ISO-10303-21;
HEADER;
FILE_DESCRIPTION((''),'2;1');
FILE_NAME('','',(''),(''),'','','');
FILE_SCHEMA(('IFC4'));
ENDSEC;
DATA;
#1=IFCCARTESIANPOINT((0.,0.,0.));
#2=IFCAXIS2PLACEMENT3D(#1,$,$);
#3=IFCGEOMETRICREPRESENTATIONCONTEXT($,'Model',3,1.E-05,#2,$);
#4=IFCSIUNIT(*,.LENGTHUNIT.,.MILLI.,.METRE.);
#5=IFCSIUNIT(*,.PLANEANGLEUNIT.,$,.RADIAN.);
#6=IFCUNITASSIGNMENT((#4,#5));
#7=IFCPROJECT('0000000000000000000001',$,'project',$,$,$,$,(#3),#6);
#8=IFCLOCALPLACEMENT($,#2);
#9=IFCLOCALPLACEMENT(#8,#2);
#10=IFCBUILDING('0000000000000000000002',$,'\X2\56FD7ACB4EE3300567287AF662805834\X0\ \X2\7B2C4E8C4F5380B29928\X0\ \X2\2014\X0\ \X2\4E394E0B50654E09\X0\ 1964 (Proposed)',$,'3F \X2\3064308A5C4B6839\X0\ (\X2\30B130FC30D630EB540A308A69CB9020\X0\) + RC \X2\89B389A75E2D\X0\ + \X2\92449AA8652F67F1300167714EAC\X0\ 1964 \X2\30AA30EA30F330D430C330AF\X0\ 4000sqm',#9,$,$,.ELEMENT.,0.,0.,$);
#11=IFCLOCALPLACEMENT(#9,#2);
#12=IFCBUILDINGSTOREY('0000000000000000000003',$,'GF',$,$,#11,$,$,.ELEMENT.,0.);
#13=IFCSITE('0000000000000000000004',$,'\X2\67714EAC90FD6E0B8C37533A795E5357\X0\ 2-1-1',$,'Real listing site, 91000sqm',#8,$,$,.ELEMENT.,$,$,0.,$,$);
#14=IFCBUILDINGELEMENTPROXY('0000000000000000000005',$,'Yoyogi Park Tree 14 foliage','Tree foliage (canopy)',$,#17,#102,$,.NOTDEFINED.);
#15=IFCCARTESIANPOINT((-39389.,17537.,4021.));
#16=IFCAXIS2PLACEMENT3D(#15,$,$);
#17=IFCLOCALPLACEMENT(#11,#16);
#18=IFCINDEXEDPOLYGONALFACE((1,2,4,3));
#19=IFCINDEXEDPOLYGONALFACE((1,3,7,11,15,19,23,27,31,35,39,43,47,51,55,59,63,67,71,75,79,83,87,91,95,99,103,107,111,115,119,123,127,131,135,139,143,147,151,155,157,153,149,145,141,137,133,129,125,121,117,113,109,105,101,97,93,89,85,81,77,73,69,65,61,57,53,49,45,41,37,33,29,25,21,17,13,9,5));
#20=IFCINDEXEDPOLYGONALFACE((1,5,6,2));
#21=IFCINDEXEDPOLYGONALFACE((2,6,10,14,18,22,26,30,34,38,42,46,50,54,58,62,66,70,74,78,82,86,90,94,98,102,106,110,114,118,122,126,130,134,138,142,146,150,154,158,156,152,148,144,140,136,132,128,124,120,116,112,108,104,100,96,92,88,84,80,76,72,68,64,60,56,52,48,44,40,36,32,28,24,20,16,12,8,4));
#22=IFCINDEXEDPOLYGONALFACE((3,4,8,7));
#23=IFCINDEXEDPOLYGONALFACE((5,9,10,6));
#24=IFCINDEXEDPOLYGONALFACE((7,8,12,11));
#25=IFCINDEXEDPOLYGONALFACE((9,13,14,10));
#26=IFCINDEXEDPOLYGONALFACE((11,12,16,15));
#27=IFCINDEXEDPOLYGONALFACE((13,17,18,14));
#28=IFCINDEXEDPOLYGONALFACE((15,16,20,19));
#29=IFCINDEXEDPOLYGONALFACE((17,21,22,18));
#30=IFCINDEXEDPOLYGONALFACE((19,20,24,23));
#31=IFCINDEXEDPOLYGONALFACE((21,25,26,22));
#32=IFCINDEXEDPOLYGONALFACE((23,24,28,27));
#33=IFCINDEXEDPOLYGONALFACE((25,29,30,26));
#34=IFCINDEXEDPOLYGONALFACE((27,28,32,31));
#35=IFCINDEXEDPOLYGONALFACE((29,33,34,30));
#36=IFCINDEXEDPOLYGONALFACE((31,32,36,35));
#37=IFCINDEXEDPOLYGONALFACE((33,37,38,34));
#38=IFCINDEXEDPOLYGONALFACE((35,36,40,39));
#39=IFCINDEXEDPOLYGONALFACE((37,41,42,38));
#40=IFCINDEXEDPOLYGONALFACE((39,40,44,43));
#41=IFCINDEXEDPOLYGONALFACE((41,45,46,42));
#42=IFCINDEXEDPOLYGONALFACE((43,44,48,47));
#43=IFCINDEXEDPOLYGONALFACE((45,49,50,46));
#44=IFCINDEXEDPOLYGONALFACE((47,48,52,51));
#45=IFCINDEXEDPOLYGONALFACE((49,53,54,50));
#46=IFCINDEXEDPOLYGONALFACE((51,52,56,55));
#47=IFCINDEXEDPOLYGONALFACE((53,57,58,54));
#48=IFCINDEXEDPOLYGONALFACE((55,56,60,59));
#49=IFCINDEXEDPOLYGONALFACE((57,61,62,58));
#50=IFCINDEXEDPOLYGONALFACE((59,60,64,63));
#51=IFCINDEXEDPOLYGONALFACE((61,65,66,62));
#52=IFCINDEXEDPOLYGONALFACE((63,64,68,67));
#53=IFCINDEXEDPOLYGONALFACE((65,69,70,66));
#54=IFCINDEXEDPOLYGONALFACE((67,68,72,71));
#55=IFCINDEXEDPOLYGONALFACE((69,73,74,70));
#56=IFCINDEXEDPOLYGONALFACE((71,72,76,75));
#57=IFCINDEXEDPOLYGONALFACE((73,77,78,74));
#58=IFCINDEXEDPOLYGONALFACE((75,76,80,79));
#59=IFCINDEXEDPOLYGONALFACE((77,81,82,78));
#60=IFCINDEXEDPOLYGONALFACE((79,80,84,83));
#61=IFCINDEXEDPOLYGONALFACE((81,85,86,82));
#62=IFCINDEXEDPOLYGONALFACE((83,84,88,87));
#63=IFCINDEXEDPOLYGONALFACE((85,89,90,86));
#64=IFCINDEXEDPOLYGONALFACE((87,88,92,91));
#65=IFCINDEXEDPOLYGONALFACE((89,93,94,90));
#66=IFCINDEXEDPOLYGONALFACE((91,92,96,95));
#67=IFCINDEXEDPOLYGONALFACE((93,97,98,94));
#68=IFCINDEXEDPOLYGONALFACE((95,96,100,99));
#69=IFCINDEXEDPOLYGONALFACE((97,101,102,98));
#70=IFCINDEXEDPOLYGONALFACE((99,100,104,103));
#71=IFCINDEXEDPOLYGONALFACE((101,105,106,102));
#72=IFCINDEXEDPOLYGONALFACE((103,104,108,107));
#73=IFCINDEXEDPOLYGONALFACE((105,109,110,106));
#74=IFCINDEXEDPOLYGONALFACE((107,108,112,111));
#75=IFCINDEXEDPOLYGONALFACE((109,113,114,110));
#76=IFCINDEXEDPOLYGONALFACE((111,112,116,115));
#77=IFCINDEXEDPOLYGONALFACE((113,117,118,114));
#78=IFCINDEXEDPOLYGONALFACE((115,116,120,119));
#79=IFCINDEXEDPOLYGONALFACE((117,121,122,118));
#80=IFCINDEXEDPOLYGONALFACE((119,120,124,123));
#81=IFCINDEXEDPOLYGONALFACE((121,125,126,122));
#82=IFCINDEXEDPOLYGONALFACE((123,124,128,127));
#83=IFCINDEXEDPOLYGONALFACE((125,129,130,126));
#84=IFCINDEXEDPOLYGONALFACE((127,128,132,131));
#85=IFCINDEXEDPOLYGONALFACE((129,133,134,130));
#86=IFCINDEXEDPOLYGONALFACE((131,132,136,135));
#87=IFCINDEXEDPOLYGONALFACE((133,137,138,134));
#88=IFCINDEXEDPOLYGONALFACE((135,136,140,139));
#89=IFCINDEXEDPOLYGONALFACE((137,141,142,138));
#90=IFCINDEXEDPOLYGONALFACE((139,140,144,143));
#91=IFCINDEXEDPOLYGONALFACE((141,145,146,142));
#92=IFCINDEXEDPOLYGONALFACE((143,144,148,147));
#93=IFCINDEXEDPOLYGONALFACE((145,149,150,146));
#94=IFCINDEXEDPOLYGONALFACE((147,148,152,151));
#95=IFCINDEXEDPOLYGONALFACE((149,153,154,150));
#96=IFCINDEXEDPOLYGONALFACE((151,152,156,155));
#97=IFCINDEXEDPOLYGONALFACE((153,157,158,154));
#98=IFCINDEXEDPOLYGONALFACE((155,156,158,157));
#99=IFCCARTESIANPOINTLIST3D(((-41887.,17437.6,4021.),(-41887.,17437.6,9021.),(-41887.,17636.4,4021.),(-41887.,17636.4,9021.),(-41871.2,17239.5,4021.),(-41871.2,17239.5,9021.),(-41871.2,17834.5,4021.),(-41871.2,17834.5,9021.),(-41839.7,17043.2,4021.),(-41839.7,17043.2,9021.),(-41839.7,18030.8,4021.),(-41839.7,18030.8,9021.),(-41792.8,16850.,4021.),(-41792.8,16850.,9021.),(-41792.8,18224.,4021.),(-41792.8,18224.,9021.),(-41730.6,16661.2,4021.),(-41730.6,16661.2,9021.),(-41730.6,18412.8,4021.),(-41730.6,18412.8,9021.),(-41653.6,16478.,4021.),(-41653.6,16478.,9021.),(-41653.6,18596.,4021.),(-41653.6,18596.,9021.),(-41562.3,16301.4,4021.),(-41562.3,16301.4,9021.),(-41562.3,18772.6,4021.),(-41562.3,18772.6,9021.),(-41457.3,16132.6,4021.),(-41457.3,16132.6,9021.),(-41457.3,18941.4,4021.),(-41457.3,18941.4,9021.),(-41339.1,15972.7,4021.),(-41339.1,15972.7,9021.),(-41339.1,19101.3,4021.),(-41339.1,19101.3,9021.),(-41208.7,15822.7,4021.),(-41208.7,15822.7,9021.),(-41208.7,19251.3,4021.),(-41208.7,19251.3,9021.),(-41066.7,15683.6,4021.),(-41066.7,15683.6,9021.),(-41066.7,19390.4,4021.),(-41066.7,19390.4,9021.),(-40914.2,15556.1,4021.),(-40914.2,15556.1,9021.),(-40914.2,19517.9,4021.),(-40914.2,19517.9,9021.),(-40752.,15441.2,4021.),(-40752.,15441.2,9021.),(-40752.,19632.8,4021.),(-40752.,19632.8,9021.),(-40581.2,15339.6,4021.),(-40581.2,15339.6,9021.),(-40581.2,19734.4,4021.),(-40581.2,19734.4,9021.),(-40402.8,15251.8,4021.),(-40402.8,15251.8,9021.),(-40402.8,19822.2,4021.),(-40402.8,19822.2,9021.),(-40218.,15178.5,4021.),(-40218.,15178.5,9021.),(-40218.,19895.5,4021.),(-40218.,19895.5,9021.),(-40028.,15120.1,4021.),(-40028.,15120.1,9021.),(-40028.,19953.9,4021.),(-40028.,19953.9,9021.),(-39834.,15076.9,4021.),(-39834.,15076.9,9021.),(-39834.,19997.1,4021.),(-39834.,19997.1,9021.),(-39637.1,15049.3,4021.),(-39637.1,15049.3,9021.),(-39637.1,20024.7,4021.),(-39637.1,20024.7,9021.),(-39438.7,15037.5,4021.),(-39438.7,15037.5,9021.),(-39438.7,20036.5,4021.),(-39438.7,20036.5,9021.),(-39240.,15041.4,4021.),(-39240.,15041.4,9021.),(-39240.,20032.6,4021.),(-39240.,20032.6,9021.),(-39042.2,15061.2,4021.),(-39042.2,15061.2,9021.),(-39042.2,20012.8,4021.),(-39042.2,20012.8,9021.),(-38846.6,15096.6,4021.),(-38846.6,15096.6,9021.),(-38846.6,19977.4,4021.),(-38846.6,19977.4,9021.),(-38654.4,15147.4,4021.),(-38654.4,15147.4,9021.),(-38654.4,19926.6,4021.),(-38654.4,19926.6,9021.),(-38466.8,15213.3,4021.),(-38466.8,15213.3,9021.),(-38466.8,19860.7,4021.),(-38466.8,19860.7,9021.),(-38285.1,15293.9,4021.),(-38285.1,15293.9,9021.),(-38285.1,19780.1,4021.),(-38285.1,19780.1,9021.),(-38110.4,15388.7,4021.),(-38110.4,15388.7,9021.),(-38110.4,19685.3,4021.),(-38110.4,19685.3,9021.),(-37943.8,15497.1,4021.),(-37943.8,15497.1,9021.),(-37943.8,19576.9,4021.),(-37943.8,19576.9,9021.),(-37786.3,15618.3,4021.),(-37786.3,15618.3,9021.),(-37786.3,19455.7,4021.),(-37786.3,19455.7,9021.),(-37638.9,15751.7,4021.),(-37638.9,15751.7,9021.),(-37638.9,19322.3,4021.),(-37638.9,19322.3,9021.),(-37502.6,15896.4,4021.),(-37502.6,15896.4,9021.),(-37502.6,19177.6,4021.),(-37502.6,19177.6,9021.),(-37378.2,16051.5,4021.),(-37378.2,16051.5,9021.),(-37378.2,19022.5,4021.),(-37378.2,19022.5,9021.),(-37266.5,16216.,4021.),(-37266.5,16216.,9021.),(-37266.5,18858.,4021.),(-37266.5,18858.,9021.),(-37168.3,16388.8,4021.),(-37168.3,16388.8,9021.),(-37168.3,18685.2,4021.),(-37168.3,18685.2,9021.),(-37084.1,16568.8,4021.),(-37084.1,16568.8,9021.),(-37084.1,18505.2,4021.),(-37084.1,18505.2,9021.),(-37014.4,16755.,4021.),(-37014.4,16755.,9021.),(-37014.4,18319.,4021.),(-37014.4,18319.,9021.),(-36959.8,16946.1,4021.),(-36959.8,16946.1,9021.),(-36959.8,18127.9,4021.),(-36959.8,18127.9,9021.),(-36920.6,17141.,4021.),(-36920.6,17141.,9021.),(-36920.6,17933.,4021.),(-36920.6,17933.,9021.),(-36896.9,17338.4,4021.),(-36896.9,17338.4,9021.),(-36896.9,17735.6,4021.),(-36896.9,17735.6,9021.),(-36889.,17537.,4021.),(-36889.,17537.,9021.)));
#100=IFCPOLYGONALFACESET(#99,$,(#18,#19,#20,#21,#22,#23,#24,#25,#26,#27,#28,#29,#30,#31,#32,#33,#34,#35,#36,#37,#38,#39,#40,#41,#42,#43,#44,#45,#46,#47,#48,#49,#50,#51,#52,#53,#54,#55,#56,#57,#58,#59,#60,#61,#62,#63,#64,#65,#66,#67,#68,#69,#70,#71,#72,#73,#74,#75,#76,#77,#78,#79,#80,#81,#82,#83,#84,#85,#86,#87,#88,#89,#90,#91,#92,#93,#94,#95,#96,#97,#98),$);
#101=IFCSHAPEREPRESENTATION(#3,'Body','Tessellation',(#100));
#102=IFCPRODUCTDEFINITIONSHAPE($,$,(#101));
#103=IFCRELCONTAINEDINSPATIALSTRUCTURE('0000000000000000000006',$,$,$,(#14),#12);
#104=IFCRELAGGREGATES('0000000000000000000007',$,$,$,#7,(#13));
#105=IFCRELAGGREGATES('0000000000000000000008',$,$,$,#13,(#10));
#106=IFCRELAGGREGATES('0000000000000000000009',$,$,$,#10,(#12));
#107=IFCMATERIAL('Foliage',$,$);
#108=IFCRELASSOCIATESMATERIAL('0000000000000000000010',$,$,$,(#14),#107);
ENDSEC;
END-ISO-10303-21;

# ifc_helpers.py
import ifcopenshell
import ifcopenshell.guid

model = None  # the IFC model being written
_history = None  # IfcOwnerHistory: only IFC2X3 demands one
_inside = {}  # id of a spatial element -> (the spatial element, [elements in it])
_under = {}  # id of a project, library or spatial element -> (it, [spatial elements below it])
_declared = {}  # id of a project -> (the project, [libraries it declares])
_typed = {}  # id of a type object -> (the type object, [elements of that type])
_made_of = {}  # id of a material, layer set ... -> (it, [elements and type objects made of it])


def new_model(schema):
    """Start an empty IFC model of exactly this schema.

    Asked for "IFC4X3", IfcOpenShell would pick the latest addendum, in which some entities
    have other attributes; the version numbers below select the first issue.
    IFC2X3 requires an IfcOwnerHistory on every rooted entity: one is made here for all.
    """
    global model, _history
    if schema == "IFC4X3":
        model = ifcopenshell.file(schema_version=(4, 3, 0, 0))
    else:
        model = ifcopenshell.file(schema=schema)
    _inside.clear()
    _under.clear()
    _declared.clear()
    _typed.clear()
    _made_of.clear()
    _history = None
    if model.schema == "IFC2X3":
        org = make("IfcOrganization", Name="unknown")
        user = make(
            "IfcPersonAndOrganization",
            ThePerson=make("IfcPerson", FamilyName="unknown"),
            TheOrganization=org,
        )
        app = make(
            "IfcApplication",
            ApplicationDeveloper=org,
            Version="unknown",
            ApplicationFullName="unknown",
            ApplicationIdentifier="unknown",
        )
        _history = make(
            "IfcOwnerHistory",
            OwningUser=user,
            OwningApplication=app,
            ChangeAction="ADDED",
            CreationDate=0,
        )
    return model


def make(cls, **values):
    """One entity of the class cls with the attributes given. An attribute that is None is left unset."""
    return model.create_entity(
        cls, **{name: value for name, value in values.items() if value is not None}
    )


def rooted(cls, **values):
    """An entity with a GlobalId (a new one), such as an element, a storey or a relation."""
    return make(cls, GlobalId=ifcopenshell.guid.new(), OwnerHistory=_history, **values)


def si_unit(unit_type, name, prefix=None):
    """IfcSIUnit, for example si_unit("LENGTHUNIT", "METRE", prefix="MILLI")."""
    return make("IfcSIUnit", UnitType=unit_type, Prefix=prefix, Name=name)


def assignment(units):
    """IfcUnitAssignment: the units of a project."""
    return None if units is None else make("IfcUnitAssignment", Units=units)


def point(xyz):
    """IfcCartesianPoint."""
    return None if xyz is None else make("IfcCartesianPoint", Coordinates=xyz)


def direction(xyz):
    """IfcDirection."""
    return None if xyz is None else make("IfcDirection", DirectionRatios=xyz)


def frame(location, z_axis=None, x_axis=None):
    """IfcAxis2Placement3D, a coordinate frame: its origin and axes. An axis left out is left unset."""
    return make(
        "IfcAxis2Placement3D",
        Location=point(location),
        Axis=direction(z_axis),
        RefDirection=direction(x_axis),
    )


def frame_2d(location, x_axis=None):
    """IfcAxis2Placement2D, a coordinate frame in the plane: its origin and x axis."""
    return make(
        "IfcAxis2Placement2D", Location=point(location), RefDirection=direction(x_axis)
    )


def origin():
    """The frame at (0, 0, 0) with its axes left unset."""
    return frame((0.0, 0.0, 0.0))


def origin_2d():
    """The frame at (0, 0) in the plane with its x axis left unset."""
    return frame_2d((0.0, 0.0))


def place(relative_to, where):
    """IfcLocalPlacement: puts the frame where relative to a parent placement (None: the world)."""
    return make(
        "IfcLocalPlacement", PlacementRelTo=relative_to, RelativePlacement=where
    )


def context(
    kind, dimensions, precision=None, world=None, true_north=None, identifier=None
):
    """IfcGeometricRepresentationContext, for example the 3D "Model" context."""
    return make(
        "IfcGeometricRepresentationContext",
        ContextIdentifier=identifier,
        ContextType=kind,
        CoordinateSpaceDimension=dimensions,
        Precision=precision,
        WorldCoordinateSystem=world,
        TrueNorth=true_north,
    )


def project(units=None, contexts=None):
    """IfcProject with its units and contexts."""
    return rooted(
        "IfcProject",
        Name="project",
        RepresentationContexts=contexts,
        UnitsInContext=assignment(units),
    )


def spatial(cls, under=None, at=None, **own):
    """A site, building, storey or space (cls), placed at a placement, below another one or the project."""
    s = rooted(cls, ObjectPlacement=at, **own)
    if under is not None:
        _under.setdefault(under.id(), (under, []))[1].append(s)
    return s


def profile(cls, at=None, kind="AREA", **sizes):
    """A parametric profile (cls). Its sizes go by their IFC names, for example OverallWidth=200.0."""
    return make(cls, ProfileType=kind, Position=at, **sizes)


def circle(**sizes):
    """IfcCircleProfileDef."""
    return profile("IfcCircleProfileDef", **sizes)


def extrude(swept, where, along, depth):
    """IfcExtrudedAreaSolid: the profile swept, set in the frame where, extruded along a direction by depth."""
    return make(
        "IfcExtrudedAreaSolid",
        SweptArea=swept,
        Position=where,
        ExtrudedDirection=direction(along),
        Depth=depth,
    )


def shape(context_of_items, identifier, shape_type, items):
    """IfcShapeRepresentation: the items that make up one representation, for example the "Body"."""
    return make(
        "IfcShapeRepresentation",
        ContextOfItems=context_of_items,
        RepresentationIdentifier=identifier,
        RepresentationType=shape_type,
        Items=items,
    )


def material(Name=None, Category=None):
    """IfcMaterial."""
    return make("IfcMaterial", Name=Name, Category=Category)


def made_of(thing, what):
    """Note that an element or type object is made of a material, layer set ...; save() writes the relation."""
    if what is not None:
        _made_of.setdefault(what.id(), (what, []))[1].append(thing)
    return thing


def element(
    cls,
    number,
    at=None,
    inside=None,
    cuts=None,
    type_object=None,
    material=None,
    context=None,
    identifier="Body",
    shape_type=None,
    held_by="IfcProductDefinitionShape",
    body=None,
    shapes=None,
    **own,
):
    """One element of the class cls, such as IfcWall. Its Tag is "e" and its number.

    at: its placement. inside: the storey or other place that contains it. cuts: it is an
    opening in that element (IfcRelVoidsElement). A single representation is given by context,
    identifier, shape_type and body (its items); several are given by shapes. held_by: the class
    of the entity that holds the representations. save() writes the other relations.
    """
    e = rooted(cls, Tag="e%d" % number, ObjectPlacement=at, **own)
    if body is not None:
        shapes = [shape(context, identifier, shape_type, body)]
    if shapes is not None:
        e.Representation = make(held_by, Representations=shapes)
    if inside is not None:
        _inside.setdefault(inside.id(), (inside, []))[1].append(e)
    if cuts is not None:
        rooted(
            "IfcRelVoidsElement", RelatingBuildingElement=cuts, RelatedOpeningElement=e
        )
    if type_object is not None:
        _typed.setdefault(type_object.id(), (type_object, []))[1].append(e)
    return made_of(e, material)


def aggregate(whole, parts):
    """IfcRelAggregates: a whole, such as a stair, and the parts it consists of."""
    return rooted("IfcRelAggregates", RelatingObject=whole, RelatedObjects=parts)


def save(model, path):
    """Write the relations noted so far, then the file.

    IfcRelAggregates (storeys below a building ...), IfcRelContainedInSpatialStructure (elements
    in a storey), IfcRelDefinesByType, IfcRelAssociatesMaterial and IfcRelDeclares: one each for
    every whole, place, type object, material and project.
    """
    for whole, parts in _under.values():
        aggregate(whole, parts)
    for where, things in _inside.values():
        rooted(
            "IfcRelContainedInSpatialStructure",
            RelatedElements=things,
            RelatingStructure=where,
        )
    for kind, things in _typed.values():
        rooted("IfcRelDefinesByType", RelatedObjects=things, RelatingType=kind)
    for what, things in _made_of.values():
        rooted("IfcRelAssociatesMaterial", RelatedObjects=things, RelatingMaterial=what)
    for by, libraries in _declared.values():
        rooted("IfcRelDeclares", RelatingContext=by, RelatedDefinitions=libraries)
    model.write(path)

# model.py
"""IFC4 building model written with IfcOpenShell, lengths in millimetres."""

from ifc_helpers import new_model, si_unit, frame, origin, origin_2d, place, context, project, spatial, circle, extrude, material, element, save


model = new_model("IFC4")

# Units and contexts
model_context = context("Model", 3, precision=1e-05, world=origin())
ifc_project = project(units=[si_unit("LENGTHUNIT", "METRE", prefix="MILLI"), si_unit("PLANEANGLEUNIT", "RADIAN")], contexts=[model_context])

# Site, building, storey
site_placement = place(None, origin())
site = spatial("IfcSite", under=ifc_project, at=site_placement, Name="東京都渋谷区神南 2-1-1", ObjectType="Real listing site, 91000sqm", CompositionType="ELEMENT", RefElevation=0.0)
building_placement = place(site_placement, origin())
building = spatial("IfcBuilding", under=site, at=building_placement, Name="国立代々木競技場 第二体育館 — 丹下健三 1964 (Proposed)", ObjectType="3F つり屋根 (ケーブル吊り構造) + RC 観覧席 + 鉄骨支柱、東京 1964 オリンピック 4000sqm", CompositionType="ELEMENT", ElevationOfRefHeight=0.0, ElevationOfTerrain=0.0)
storey_placement = place(building_placement, origin())
storey = spatial("IfcBuildingStorey", under=building, at=storey_placement, Name="GF", CompositionType="ELEMENT", Elevation=0.0)

# Building element proxy
ifc_material_1 = material(Name="Foliage")
proxy_1_placement = place(storey_placement, frame((-39389.0, 17537.0, 4021.0)))
element("IfcBuildingElementProxy", 1, at=proxy_1_placement, inside=storey, material=ifc_material_1, Name="Yoyogi Park Tree 14 foliage", Description="Tree foliage (canopy)", PredefinedType="NOTDEFINED", context=model_context, shape_type="SweptSolid", body=[
    extrude(circle(Radius=2500.0, at=origin_2d()), frame((-39389.0, 17537.0, 4021.0)), (0.0, 0.0, 1.0), 5000.0),
])

save(model, "model.ifc")
